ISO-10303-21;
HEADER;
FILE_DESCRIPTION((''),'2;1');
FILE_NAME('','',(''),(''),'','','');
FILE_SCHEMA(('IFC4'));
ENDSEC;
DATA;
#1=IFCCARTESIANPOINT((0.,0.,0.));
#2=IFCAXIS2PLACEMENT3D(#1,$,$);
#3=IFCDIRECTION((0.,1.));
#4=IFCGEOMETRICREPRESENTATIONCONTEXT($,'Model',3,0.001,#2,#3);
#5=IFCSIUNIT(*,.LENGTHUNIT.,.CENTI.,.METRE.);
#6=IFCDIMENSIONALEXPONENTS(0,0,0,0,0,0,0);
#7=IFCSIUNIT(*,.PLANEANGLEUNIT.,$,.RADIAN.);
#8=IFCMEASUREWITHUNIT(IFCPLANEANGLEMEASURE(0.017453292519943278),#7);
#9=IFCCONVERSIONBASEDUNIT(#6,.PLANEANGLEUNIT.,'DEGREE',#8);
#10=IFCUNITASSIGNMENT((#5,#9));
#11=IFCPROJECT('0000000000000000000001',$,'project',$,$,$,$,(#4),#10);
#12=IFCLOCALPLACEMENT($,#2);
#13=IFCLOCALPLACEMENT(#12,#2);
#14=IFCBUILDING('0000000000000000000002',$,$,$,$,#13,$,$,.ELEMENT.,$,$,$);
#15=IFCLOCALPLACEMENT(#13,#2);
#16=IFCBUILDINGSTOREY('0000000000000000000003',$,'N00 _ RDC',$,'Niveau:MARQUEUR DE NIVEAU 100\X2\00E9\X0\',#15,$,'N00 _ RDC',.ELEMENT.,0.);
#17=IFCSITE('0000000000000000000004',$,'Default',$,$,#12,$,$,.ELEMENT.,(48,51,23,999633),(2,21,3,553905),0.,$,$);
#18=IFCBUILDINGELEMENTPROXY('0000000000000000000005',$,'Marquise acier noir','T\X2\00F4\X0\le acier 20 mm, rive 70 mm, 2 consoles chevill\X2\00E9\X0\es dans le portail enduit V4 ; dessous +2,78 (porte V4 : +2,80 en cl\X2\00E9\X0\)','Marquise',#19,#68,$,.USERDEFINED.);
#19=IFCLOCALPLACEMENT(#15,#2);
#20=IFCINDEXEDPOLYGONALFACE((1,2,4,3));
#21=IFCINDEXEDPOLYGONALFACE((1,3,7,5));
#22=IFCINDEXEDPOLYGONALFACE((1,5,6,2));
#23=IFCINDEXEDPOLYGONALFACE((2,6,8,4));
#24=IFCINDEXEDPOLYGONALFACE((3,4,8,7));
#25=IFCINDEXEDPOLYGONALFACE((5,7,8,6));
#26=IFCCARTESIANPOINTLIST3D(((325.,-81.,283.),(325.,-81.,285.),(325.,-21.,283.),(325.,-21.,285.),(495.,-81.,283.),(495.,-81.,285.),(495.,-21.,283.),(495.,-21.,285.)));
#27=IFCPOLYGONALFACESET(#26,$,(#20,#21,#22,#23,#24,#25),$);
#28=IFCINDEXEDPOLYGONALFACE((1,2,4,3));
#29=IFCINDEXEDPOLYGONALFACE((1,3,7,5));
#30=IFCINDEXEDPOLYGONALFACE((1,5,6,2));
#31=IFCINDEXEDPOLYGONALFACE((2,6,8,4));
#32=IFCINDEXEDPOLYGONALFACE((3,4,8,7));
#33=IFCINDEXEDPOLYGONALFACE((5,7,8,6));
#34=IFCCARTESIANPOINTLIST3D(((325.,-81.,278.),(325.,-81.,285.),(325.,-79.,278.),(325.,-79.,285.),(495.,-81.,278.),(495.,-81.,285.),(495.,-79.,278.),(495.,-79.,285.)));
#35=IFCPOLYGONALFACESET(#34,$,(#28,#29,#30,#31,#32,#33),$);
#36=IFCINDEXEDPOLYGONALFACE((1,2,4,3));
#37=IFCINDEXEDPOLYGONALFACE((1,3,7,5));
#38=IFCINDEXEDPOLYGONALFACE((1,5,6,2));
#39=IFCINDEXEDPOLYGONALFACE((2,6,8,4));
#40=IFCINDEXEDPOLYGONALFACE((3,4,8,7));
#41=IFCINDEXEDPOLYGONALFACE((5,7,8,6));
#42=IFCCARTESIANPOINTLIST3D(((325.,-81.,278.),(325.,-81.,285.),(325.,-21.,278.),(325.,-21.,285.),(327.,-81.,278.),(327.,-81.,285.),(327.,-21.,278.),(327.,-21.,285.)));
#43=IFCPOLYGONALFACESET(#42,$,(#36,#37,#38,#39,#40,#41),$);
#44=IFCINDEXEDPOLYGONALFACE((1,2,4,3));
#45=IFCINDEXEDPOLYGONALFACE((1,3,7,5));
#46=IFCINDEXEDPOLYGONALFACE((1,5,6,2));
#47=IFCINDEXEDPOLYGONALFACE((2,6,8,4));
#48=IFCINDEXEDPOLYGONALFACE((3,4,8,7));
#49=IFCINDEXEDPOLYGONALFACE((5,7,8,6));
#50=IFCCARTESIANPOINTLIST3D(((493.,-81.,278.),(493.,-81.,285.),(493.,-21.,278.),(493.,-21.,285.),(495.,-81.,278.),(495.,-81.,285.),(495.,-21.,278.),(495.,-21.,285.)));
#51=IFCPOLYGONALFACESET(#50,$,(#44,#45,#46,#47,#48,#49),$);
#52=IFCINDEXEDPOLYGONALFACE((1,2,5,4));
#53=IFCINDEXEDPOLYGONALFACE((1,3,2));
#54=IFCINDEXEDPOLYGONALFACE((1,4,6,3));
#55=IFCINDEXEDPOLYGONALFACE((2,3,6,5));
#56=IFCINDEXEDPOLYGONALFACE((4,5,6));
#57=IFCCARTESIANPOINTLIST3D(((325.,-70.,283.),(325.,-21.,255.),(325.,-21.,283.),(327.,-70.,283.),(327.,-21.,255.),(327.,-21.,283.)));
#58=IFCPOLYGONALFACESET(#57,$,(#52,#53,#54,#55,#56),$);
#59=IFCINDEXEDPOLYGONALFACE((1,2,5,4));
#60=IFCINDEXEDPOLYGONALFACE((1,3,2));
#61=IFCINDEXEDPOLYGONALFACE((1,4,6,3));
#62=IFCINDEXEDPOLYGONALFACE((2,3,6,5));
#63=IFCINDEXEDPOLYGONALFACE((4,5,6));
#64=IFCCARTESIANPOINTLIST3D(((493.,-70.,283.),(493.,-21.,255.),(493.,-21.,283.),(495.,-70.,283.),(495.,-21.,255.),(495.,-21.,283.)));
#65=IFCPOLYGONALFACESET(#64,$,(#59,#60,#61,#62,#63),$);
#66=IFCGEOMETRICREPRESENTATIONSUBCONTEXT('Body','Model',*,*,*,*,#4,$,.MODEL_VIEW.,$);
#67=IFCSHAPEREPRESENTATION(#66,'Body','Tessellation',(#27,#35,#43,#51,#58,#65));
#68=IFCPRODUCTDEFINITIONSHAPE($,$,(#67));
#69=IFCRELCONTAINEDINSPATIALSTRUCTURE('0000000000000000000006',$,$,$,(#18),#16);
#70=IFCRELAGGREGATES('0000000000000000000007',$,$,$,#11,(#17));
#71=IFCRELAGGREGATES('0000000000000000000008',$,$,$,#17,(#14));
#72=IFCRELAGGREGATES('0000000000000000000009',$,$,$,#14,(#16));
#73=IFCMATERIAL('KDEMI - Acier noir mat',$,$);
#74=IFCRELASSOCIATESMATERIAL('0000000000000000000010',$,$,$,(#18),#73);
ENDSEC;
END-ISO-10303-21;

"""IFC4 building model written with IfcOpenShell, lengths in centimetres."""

from ifc_helpers import new_model, entity, si_unit, converted_unit, direction, frame, frame_2d, origin, origin_with_axes, place, context, subcontext, project, spatial, polyline, rectangle, outline, extrude, material, element, save


model = new_model("IFC4")

# Units and contexts
model_context = context("Model", 3, precision=0.001, world=origin(), true_north=direction((0.0, 1.0)))
body_context = subcontext(model_context, "Body", "Model", "MODEL_VIEW")
ifc_project = project(units=[si_unit("LENGTHUNIT", "METRE", prefix="CENTI"), converted_unit("PLANEANGLEUNIT", "DEGREE", entity("IfcPlaneAngleMeasure", 0.017453292519943278), si_unit("PLANEANGLEUNIT", "RADIAN"), dimensions=[0, 0, 0, 0, 0, 0, 0])], contexts=[model_context])

# Site, building, storey
site_placement = place(None, origin())
site = spatial("IfcSite", under=ifc_project, at=site_placement, Name="Default", CompositionType="ELEMENT", RefLatitude=(48, 51, 23, 999633), RefLongitude=(2, 21, 3, 553905), RefElevation=0.0)
building_placement = place(site_placement, origin())
building = spatial("IfcBuilding", under=site, at=building_placement, CompositionType="ELEMENT")
storey_placement = place(building_placement, origin())
storey = spatial("IfcBuildingStorey", under=building, at=storey_placement, Name="N00 _ RDC", ObjectType="Niveau:MARQUEUR DE NIVEAU 100é", LongName="N00 _ RDC", CompositionType="ELEMENT", Elevation=0.0)

# Shared definitions
ifc_material_1 = material(Name="KDEMI - Acier noir mat")

# Building element proxy
proxy_1_placement = place(storey_placement, origin_with_axes())
element("IfcBuildingElementProxy", 1, at=proxy_1_placement, inside=storey, material=ifc_material_1, Name="Marquise acier noir", Description="Tôle acier 20 mm, rive 70 mm, 2 consoles chevillées dans le portail enduit V4 ; dessous +2,78 (porte V4 : +2,80 en clé)", ObjectType="Marquise", PredefinedType="USERDEFINED", context=body_context, shape_type="SweptSolid", body=[
    extrude(rectangle(XDim=170.0, YDim=60.0, at=frame_2d((410.0, -51.0))), frame((0.0, 0.0, 283.0)), (0.0, 0.0, 1.0), 2.0),
    extrude(rectangle(XDim=170.0, YDim=2.0, at=frame_2d((410.0, -80.0))), frame((0.0, 0.0, 278.0)), (0.0, 0.0, 1.0), 7.0),
    extrude(rectangle(XDim=2.0, YDim=60.0, at=frame_2d((326.0, -51.0))), frame((0.0, 0.0, 278.0)), (0.0, 0.0, 1.0), 7.0),
    extrude(rectangle(XDim=2.0, YDim=60.0, at=frame_2d((494.0, -51.0))), frame((0.0, 0.0, 278.0)), (0.0, 0.0, 1.0), 7.0),
    extrude(outline(polyline([(-21.0, 255.0), (-70.0, 283.0), (-21.0, 283.0), (-21.0, 255.0)])), frame((325.0, 0.0, 0.0), z_axis=(1.0, 0.0, 0.0), x_axis=(0.0, 1.0, 0.0)), (0.0, 0.0, 1.0), 2.0),
    extrude(outline(polyline([(-21.0, 255.0), (-70.0, 283.0), (-21.0, 283.0), (-21.0, 255.0)])), frame((493.0, 0.0, 0.0), z_axis=(1.0, 0.0, 0.0), x_axis=(0.0, 1.0, 0.0)), (0.0, 0.0, 1.0), 2.0),
])

save(model, "model.ifc")
